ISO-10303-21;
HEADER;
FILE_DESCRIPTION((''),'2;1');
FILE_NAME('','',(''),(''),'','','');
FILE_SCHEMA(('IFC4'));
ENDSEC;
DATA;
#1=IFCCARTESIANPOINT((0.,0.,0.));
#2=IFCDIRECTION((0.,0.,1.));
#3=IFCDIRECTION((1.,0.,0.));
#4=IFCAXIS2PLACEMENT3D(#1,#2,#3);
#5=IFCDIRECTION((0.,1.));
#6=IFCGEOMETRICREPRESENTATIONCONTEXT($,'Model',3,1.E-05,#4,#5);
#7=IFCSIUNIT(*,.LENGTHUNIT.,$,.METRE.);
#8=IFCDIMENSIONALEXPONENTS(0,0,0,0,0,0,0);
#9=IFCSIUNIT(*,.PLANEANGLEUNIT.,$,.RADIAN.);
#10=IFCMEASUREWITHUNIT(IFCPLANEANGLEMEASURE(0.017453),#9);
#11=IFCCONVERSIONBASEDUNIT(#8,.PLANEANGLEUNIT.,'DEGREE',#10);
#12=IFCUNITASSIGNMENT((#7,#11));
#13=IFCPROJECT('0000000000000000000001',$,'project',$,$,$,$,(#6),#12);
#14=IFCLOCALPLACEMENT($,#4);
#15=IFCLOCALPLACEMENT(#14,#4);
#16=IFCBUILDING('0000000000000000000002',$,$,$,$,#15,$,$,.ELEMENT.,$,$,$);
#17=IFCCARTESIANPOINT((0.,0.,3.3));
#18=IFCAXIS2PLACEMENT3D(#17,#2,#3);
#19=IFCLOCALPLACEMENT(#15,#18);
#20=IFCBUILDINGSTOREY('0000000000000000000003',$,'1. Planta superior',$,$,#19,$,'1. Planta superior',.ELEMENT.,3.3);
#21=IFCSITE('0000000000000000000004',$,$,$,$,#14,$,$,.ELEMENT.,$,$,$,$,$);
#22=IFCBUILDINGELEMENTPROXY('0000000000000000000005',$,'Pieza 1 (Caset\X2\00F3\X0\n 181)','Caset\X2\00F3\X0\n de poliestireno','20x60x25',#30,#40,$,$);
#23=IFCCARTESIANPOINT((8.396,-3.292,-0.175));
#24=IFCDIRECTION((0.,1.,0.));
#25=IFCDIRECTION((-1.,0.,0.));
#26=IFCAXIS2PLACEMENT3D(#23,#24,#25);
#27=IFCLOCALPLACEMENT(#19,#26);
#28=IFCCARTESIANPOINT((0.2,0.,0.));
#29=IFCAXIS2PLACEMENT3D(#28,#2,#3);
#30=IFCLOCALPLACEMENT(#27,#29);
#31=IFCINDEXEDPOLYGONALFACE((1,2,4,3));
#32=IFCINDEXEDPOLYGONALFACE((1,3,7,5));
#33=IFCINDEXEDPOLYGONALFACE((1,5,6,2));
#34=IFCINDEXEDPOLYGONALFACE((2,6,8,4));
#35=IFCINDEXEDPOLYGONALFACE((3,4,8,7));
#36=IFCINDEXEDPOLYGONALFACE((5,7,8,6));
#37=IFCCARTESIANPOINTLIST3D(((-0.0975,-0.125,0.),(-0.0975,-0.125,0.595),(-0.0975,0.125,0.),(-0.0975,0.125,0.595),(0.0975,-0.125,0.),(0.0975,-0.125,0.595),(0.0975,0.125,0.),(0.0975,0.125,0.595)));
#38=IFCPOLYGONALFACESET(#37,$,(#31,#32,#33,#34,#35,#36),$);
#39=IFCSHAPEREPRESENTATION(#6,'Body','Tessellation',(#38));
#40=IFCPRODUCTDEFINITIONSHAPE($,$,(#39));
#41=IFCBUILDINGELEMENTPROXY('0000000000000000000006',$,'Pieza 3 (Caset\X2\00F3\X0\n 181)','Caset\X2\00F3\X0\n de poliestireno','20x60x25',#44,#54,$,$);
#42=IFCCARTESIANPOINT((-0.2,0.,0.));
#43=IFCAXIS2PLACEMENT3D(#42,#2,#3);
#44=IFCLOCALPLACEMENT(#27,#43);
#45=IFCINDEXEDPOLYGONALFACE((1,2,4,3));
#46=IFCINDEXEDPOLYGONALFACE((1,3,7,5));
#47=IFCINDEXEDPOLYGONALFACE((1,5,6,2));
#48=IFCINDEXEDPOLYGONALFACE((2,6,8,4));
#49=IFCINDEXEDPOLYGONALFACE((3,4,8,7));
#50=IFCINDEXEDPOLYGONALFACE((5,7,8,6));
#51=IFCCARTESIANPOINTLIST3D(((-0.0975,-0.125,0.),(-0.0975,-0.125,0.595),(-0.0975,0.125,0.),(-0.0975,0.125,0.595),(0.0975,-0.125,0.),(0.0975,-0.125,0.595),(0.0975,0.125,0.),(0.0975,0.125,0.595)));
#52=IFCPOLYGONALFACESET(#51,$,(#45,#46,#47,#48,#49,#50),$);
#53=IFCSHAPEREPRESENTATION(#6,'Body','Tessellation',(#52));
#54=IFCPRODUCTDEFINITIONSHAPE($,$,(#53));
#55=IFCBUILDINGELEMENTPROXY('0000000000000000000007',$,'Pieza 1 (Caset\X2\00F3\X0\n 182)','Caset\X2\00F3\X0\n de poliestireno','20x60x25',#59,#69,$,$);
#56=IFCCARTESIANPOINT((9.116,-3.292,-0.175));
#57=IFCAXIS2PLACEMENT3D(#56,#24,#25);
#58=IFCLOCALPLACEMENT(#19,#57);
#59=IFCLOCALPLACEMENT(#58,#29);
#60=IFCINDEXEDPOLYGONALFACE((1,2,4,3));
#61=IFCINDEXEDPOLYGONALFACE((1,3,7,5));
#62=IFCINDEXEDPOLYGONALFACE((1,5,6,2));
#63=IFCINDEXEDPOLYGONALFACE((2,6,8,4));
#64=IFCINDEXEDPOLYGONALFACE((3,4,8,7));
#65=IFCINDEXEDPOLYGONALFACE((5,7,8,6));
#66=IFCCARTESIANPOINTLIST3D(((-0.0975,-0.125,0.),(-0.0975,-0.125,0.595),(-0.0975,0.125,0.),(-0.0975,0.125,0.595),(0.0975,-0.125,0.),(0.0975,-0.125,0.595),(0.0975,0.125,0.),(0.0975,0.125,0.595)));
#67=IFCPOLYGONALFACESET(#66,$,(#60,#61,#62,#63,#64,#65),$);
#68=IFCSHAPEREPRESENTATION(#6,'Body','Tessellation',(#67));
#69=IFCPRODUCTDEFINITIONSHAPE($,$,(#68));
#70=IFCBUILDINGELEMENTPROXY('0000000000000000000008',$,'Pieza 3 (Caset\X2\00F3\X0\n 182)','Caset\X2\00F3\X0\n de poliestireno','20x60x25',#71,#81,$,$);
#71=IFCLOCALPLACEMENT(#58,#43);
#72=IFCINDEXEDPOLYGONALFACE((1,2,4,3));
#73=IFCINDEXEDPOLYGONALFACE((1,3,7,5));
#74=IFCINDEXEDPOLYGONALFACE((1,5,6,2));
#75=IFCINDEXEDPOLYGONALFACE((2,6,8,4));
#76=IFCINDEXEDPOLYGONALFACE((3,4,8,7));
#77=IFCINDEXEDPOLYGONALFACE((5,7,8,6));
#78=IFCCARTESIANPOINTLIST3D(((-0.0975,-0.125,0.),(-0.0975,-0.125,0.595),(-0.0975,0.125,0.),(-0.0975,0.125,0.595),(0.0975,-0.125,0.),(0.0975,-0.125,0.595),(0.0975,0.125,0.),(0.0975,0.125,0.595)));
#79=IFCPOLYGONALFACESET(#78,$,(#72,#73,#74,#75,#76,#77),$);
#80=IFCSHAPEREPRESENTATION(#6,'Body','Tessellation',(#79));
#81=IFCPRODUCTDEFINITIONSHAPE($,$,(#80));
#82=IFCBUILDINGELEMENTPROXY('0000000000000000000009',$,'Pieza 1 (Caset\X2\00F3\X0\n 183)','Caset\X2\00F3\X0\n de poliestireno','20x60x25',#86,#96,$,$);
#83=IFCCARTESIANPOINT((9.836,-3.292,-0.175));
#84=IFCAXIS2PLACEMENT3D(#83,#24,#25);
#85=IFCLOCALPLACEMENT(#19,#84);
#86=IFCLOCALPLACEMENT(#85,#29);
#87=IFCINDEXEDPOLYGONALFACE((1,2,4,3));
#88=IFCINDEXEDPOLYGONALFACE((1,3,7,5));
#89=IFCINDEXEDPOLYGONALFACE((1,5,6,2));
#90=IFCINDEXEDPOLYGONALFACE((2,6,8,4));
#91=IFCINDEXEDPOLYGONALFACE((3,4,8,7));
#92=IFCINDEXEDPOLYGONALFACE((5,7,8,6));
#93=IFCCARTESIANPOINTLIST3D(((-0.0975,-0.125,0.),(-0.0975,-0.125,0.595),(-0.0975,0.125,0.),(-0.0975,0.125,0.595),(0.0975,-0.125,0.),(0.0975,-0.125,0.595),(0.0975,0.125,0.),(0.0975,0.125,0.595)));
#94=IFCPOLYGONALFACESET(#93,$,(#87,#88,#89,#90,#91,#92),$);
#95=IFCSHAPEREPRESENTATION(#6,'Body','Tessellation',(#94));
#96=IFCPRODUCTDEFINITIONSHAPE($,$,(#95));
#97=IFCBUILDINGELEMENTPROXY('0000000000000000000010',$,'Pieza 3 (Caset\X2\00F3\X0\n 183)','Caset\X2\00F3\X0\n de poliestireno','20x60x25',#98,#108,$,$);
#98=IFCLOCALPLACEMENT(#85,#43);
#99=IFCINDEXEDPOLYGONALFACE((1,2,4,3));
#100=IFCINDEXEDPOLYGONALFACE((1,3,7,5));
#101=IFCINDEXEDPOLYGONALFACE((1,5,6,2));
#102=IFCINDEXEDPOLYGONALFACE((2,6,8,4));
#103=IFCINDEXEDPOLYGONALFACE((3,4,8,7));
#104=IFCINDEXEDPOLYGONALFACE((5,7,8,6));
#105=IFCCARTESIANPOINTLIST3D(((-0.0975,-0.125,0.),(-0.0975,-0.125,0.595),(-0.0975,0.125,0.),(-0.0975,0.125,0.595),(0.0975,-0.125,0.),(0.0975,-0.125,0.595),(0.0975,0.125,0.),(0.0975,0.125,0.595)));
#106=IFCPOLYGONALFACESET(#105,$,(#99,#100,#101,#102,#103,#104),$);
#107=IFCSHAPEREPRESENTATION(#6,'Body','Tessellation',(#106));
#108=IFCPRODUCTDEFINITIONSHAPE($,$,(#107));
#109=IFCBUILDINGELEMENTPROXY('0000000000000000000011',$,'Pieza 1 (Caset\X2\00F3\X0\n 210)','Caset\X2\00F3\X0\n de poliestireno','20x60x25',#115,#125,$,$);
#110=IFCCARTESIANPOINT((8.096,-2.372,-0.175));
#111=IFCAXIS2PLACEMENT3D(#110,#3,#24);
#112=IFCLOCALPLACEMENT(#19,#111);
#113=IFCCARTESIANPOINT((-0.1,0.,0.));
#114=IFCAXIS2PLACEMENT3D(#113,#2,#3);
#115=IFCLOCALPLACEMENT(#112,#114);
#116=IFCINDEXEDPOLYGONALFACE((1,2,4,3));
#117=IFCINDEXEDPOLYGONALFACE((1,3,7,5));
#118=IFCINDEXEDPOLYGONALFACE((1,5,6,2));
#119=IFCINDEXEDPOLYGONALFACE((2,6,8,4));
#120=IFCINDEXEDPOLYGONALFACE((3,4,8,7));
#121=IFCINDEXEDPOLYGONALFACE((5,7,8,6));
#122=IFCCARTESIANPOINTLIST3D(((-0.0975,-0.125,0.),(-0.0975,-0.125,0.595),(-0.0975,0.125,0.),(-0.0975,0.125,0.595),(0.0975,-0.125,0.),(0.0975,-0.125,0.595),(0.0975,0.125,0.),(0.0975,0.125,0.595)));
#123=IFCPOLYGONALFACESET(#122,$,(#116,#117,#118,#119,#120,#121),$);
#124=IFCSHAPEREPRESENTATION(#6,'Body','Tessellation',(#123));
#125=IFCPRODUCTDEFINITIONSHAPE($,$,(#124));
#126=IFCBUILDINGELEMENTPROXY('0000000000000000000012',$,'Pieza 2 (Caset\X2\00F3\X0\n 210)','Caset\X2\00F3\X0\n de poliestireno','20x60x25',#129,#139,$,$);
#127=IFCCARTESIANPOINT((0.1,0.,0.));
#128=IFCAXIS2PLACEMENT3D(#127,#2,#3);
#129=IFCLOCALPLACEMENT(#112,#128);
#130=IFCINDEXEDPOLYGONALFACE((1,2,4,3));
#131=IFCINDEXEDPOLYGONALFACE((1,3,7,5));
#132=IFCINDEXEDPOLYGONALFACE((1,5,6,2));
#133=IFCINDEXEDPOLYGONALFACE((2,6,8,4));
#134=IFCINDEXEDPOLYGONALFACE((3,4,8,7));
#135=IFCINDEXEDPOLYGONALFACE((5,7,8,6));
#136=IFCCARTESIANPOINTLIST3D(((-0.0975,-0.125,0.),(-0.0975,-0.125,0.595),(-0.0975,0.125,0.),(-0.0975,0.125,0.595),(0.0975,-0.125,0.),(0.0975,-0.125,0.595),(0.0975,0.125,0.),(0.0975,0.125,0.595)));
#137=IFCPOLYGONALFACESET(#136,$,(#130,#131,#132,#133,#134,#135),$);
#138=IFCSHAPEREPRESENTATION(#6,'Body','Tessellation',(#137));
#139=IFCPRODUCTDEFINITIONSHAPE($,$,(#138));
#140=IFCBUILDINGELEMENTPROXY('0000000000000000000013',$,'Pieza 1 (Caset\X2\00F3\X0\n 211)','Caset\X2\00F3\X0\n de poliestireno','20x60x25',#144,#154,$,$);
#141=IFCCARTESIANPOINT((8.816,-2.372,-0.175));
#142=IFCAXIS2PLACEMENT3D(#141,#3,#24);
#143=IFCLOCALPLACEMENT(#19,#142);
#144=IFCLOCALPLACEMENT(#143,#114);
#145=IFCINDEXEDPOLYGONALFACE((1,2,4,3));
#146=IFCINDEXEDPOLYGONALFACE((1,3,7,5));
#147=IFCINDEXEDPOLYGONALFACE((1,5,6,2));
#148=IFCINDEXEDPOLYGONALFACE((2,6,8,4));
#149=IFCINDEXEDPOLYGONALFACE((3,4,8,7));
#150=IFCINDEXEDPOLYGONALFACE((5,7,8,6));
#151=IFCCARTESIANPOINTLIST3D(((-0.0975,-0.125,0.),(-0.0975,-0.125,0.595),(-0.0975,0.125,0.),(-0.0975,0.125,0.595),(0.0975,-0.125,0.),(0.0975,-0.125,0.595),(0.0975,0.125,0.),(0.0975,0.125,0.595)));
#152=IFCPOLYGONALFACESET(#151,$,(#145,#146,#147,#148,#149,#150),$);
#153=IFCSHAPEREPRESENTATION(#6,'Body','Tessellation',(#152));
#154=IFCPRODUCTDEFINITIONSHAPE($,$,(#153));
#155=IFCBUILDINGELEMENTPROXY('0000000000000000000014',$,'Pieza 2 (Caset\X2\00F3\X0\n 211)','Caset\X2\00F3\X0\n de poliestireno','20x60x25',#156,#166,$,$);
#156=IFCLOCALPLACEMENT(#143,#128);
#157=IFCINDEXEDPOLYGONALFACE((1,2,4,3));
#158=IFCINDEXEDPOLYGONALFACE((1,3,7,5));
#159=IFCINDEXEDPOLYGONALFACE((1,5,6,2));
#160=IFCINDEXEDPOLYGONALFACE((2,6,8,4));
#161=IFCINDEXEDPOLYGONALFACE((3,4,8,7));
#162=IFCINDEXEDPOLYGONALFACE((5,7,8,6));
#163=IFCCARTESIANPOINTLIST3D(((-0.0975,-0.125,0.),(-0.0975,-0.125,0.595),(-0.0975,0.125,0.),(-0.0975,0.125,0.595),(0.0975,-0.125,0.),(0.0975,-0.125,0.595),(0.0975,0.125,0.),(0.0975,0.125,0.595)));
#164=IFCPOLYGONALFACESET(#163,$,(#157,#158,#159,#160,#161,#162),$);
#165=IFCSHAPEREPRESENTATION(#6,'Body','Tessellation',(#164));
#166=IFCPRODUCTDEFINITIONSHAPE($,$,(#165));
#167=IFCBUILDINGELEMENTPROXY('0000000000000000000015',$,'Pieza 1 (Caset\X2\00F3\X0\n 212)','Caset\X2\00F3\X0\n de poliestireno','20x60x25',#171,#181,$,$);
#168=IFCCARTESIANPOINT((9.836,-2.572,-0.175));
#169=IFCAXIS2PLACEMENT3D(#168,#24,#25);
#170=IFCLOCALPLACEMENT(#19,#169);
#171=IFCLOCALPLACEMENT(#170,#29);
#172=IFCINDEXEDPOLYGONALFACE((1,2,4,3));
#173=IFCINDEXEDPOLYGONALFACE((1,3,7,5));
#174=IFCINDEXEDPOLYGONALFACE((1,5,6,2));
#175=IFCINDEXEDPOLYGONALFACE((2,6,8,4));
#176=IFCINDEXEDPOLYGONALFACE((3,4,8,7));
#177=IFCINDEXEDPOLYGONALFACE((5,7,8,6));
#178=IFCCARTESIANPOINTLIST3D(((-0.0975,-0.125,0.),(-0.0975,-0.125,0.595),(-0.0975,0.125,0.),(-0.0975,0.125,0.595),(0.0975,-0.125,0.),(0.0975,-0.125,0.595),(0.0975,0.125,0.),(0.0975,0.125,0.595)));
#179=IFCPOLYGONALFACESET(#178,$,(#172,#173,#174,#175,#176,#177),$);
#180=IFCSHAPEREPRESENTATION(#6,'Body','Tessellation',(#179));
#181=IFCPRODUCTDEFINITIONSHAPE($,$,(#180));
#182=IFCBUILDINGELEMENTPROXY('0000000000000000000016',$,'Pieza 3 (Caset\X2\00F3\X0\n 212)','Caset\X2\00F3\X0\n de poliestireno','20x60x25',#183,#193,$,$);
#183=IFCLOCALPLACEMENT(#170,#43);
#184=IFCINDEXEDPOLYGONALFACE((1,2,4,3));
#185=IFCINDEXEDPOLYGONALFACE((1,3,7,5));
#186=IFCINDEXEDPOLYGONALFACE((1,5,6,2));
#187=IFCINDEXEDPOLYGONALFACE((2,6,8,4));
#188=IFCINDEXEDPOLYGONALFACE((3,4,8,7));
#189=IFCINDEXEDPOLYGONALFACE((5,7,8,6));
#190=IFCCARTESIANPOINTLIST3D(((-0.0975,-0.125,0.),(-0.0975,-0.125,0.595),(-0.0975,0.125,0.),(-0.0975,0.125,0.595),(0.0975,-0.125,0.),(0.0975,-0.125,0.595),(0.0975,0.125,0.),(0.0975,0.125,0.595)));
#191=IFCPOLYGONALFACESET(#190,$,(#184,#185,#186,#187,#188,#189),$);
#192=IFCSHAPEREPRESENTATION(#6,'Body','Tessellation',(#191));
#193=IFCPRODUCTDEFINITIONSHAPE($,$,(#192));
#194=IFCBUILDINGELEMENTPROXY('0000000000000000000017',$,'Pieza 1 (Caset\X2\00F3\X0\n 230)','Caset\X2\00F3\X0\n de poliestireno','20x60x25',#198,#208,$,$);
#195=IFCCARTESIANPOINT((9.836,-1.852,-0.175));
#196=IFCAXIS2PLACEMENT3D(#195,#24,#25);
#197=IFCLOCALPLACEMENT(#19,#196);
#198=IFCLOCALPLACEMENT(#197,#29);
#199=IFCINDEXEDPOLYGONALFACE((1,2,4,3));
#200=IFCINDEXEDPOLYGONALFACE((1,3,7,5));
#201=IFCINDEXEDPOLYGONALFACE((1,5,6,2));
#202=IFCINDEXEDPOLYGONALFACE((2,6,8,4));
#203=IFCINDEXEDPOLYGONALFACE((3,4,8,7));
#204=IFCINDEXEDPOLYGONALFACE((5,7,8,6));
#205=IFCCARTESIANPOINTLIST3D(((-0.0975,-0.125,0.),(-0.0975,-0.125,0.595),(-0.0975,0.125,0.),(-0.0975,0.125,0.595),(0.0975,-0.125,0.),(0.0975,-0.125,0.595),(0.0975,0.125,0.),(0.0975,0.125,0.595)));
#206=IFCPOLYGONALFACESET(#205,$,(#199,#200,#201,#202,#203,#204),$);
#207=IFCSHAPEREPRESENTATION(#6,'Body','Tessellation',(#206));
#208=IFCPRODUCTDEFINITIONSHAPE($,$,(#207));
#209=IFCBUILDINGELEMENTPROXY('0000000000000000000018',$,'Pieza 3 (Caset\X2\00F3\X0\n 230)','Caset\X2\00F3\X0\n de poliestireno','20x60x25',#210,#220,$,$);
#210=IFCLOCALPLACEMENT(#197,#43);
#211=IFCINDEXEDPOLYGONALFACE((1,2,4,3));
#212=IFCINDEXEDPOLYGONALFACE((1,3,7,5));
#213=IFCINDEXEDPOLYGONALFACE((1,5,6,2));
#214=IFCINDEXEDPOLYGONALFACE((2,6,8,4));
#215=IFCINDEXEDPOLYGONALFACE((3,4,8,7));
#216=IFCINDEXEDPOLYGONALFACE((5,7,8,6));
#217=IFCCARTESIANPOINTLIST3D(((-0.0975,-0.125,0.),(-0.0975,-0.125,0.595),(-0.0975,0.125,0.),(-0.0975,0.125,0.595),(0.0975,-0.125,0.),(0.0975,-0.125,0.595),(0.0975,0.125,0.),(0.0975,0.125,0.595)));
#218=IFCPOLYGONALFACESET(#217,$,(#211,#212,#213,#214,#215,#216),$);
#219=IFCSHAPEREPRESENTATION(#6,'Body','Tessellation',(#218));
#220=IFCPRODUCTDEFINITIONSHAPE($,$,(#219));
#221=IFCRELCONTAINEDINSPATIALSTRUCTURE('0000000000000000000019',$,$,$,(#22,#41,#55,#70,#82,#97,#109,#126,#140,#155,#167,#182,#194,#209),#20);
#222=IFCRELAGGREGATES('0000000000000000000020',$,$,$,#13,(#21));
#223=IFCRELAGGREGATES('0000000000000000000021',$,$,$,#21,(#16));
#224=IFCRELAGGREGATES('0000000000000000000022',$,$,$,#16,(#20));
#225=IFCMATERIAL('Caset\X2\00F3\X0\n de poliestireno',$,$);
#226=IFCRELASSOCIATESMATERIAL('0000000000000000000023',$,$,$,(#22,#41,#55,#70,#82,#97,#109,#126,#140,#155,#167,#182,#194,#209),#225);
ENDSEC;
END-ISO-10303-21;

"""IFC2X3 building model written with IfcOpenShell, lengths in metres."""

from ifc_helpers import new_model, entity, si_unit, converted_unit, direction, frame, origin_with_axes, origin_2d_with_axis, place, context, project, spatial, rectangle, extrude, source, transform, mapped, material, element, save


model = new_model("IFC2X3")

# Units and contexts
model_context = context("Model", 3, precision=1e-05, world=origin_with_axes(), true_north=direction((0.0, 1.0)))
ifc_project = project(units=[si_unit("LENGTHUNIT", "METRE"), converted_unit("PLANEANGLEUNIT", "DEGREE", entity("IfcPlaneAngleMeasure", 0.017453), si_unit("PLANEANGLEUNIT", "RADIAN"), dimensions=[0, 0, 0, 0, 0, 0, 0])], contexts=[model_context])

# Site, building, storey
site_placement = place(None, origin_with_axes())
site = spatial("IfcSite", under=ifc_project, at=site_placement, CompositionType="ELEMENT")
building_placement = place(site_placement, origin_with_axes())
building = spatial("IfcBuilding", under=site, at=building_placement, CompositionType="ELEMENT")
storey_placement = place(building_placement, frame((0.0, 0.0, 3.3), z_axis=(0.0, 0.0, 1.0), x_axis=(1.0, 0.0, 0.0)))
storey = spatial("IfcBuildingStorey", under=building, at=storey_placement, Name="1. Planta superior", LongName="1. Planta superior", CompositionType="ELEMENT", Elevation=3.3)

# Building element proxies
ifc_material_1 = material(Name="Casetón de poliestireno")
shared_shape = source(origin_with_axes(), model_context, "Body", "SweptSolid", [
    extrude(rectangle(XDim=0.195, YDim=0.25, at=origin_2d_with_axis()), origin_with_axes(), (0.0, 0.0, 1.0), 0.595),
])
placement_1 = place(storey_placement, frame((8.396, -3.292, -0.175), z_axis=(0.0, 1.0, 0.0), x_axis=(-1.0, 0.0, 0.0)))
for number, where, z_axis, x_axis, name in (
    (1, (0.2, 0.0, 0.0), (0.0, 0.0, 1.0), (1.0, 0.0, 0.0), "Pieza 1 (Casetón 181)"),
    (2, (-0.2, 0.0, 0.0), (0.0, 0.0, 1.0), (1.0, 0.0, 0.0), "Pieza 3 (Casetón 181)"),
):
    element("IfcBuildingElementProxy", number, at=place(placement_1, frame(where, z_axis=z_axis, x_axis=x_axis)), inside=storey, material=ifc_material_1, Name=name, Description="Casetón de poliestireno", ObjectType="20x60x25", context=model_context, shape_type="MappedRepresentation", body=[
        mapped(shared_shape, transform((0.0, 0.0, 0.0), x_axis=(1.0, 0.0, 0.0), y_axis=(0.0, 1.0, 0.0), z_axis=(0.0, 0.0, 1.0))),
    ])
placement_2 = place(storey_placement, frame((9.116, -3.292, -0.175), z_axis=(0.0, 1.0, 0.0), x_axis=(-1.0, 0.0, 0.0)))
for number, where, z_axis, x_axis, name in (
    (3, (0.2, 0.0, 0.0), (0.0, 0.0, 1.0), (1.0, 0.0, 0.0), "Pieza 1 (Casetón 182)"),
    (4, (-0.2, 0.0, 0.0), (0.0, 0.0, 1.0), (1.0, 0.0, 0.0), "Pieza 3 (Casetón 182)"),
):
    element("IfcBuildingElementProxy", number, at=place(placement_2, frame(where, z_axis=z_axis, x_axis=x_axis)), inside=storey, material=ifc_material_1, Name=name, Description="Casetón de poliestireno", ObjectType="20x60x25", context=model_context, shape_type="MappedRepresentation", body=[
        mapped(shared_shape, transform((0.0, 0.0, 0.0), x_axis=(1.0, 0.0, 0.0), y_axis=(0.0, 1.0, 0.0), z_axis=(0.0, 0.0, 1.0))),
    ])
placement_3 = place(storey_placement, frame((9.836, -3.292, -0.175), z_axis=(0.0, 1.0, 0.0), x_axis=(-1.0, 0.0, 0.0)))
for number, where, z_axis, x_axis, name in (
    (5, (0.2, 0.0, 0.0), (0.0, 0.0, 1.0), (1.0, 0.0, 0.0), "Pieza 1 (Casetón 183)"),
    (6, (-0.2, 0.0, 0.0), (0.0, 0.0, 1.0), (1.0, 0.0, 0.0), "Pieza 3 (Casetón 183)"),
):
    element("IfcBuildingElementProxy", number, at=place(placement_3, frame(where, z_axis=z_axis, x_axis=x_axis)), inside=storey, material=ifc_material_1, Name=name, Description="Casetón de poliestireno", ObjectType="20x60x25", context=model_context, shape_type="MappedRepresentation", body=[
        mapped(shared_shape, transform((0.0, 0.0, 0.0), x_axis=(1.0, 0.0, 0.0), y_axis=(0.0, 1.0, 0.0), z_axis=(0.0, 0.0, 1.0))),
    ])
placement_4 = place(storey_placement, frame((8.096, -2.372, -0.175), z_axis=(1.0, 0.0, 0.0), x_axis=(0.0, 1.0, 0.0)))
for number, where, z_axis, x_axis, name in (
    (7, (-0.1, 0.0, 0.0), (0.0, 0.0, 1.0), (1.0, 0.0, 0.0), "Pieza 1 (Casetón 210)"),
    (8, (0.1, 0.0, 0.0), (0.0, 0.0, 1.0), (1.0, 0.0, 0.0), "Pieza 2 (Casetón 210)"),
):
    element("IfcBuildingElementProxy", number, at=place(placement_4, frame(where, z_axis=z_axis, x_axis=x_axis)), inside=storey, material=ifc_material_1, Name=name, Description="Casetón de poliestireno", ObjectType="20x60x25", context=model_context, shape_type="MappedRepresentation", body=[
        mapped(shared_shape, transform((0.0, 0.0, 0.0), x_axis=(1.0, 0.0, 0.0), y_axis=(0.0, 1.0, 0.0), z_axis=(0.0, 0.0, 1.0))),
    ])
placement_5 = place(storey_placement, frame((8.816, -2.372, -0.175), z_axis=(1.0, 0.0, 0.0), x_axis=(0.0, 1.0, 0.0)))
for number, where, z_axis, x_axis, name in (
    (9, (-0.1, 0.0, 0.0), (0.0, 0.0, 1.0), (1.0, 0.0, 0.0), "Pieza 1 (Casetón 211)"),
    (10, (0.1, 0.0, 0.0), (0.0, 0.0, 1.0), (1.0, 0.0, 0.0), "Pieza 2 (Casetón 211)"),
):
    element("IfcBuildingElementProxy", number, at=place(placement_5, frame(where, z_axis=z_axis, x_axis=x_axis)), inside=storey, material=ifc_material_1, Name=name, Description="Casetón de poliestireno", ObjectType="20x60x25", context=model_context, shape_type="MappedRepresentation", body=[
        mapped(shared_shape, transform((0.0, 0.0, 0.0), x_axis=(1.0, 0.0, 0.0), y_axis=(0.0, 1.0, 0.0), z_axis=(0.0, 0.0, 1.0))),
    ])
placement_6 = place(storey_placement, frame((9.836, -2.572, -0.175), z_axis=(0.0, 1.0, 0.0), x_axis=(-1.0, 0.0, 0.0)))
for number, where, z_axis, x_axis, name in (
    (11, (0.2, 0.0, 0.0), (0.0, 0.0, 1.0), (1.0, 0.0, 0.0), "Pieza 1 (Casetón 212)"),
    (12, (-0.2, 0.0, 0.0), (0.0, 0.0, 1.0), (1.0, 0.0, 0.0), "Pieza 3 (Casetón 212)"),
):
    element("IfcBuildingElementProxy", number, at=place(placement_6, frame(where, z_axis=z_axis, x_axis=x_axis)), inside=storey, material=ifc_material_1, Name=name, Description="Casetón de poliestireno", ObjectType="20x60x25", context=model_context, shape_type="MappedRepresentation", body=[
        mapped(shared_shape, transform((0.0, 0.0, 0.0), x_axis=(1.0, 0.0, 0.0), y_axis=(0.0, 1.0, 0.0), z_axis=(0.0, 0.0, 1.0))),
    ])
placement_7 = place(storey_placement, frame((9.836, -1.852, -0.175), z_axis=(0.0, 1.0, 0.0), x_axis=(-1.0, 0.0, 0.0)))
for number, where, z_axis, x_axis, name in (
    (13, (0.2, 0.0, 0.0), (0.0, 0.0, 1.0), (1.0, 0.0, 0.0), "Pieza 1 (Casetón 230)"),
    (14, (-0.2, 0.0, 0.0), (0.0, 0.0, 1.0), (1.0, 0.0, 0.0), "Pieza 3 (Casetón 230)"),
):
    element("IfcBuildingElementProxy", number, at=place(placement_7, frame(where, z_axis=z_axis, x_axis=x_axis)), inside=storey, material=ifc_material_1, Name=name, Description="Casetón de poliestireno", ObjectType="20x60x25", context=model_context, shape_type="MappedRepresentation", body=[
        mapped(shared_shape, transform((0.0, 0.0, 0.0), x_axis=(1.0, 0.0, 0.0), y_axis=(0.0, 1.0, 0.0), z_axis=(0.0, 0.0, 1.0))),
    ])

save(model, "model.ifc")
